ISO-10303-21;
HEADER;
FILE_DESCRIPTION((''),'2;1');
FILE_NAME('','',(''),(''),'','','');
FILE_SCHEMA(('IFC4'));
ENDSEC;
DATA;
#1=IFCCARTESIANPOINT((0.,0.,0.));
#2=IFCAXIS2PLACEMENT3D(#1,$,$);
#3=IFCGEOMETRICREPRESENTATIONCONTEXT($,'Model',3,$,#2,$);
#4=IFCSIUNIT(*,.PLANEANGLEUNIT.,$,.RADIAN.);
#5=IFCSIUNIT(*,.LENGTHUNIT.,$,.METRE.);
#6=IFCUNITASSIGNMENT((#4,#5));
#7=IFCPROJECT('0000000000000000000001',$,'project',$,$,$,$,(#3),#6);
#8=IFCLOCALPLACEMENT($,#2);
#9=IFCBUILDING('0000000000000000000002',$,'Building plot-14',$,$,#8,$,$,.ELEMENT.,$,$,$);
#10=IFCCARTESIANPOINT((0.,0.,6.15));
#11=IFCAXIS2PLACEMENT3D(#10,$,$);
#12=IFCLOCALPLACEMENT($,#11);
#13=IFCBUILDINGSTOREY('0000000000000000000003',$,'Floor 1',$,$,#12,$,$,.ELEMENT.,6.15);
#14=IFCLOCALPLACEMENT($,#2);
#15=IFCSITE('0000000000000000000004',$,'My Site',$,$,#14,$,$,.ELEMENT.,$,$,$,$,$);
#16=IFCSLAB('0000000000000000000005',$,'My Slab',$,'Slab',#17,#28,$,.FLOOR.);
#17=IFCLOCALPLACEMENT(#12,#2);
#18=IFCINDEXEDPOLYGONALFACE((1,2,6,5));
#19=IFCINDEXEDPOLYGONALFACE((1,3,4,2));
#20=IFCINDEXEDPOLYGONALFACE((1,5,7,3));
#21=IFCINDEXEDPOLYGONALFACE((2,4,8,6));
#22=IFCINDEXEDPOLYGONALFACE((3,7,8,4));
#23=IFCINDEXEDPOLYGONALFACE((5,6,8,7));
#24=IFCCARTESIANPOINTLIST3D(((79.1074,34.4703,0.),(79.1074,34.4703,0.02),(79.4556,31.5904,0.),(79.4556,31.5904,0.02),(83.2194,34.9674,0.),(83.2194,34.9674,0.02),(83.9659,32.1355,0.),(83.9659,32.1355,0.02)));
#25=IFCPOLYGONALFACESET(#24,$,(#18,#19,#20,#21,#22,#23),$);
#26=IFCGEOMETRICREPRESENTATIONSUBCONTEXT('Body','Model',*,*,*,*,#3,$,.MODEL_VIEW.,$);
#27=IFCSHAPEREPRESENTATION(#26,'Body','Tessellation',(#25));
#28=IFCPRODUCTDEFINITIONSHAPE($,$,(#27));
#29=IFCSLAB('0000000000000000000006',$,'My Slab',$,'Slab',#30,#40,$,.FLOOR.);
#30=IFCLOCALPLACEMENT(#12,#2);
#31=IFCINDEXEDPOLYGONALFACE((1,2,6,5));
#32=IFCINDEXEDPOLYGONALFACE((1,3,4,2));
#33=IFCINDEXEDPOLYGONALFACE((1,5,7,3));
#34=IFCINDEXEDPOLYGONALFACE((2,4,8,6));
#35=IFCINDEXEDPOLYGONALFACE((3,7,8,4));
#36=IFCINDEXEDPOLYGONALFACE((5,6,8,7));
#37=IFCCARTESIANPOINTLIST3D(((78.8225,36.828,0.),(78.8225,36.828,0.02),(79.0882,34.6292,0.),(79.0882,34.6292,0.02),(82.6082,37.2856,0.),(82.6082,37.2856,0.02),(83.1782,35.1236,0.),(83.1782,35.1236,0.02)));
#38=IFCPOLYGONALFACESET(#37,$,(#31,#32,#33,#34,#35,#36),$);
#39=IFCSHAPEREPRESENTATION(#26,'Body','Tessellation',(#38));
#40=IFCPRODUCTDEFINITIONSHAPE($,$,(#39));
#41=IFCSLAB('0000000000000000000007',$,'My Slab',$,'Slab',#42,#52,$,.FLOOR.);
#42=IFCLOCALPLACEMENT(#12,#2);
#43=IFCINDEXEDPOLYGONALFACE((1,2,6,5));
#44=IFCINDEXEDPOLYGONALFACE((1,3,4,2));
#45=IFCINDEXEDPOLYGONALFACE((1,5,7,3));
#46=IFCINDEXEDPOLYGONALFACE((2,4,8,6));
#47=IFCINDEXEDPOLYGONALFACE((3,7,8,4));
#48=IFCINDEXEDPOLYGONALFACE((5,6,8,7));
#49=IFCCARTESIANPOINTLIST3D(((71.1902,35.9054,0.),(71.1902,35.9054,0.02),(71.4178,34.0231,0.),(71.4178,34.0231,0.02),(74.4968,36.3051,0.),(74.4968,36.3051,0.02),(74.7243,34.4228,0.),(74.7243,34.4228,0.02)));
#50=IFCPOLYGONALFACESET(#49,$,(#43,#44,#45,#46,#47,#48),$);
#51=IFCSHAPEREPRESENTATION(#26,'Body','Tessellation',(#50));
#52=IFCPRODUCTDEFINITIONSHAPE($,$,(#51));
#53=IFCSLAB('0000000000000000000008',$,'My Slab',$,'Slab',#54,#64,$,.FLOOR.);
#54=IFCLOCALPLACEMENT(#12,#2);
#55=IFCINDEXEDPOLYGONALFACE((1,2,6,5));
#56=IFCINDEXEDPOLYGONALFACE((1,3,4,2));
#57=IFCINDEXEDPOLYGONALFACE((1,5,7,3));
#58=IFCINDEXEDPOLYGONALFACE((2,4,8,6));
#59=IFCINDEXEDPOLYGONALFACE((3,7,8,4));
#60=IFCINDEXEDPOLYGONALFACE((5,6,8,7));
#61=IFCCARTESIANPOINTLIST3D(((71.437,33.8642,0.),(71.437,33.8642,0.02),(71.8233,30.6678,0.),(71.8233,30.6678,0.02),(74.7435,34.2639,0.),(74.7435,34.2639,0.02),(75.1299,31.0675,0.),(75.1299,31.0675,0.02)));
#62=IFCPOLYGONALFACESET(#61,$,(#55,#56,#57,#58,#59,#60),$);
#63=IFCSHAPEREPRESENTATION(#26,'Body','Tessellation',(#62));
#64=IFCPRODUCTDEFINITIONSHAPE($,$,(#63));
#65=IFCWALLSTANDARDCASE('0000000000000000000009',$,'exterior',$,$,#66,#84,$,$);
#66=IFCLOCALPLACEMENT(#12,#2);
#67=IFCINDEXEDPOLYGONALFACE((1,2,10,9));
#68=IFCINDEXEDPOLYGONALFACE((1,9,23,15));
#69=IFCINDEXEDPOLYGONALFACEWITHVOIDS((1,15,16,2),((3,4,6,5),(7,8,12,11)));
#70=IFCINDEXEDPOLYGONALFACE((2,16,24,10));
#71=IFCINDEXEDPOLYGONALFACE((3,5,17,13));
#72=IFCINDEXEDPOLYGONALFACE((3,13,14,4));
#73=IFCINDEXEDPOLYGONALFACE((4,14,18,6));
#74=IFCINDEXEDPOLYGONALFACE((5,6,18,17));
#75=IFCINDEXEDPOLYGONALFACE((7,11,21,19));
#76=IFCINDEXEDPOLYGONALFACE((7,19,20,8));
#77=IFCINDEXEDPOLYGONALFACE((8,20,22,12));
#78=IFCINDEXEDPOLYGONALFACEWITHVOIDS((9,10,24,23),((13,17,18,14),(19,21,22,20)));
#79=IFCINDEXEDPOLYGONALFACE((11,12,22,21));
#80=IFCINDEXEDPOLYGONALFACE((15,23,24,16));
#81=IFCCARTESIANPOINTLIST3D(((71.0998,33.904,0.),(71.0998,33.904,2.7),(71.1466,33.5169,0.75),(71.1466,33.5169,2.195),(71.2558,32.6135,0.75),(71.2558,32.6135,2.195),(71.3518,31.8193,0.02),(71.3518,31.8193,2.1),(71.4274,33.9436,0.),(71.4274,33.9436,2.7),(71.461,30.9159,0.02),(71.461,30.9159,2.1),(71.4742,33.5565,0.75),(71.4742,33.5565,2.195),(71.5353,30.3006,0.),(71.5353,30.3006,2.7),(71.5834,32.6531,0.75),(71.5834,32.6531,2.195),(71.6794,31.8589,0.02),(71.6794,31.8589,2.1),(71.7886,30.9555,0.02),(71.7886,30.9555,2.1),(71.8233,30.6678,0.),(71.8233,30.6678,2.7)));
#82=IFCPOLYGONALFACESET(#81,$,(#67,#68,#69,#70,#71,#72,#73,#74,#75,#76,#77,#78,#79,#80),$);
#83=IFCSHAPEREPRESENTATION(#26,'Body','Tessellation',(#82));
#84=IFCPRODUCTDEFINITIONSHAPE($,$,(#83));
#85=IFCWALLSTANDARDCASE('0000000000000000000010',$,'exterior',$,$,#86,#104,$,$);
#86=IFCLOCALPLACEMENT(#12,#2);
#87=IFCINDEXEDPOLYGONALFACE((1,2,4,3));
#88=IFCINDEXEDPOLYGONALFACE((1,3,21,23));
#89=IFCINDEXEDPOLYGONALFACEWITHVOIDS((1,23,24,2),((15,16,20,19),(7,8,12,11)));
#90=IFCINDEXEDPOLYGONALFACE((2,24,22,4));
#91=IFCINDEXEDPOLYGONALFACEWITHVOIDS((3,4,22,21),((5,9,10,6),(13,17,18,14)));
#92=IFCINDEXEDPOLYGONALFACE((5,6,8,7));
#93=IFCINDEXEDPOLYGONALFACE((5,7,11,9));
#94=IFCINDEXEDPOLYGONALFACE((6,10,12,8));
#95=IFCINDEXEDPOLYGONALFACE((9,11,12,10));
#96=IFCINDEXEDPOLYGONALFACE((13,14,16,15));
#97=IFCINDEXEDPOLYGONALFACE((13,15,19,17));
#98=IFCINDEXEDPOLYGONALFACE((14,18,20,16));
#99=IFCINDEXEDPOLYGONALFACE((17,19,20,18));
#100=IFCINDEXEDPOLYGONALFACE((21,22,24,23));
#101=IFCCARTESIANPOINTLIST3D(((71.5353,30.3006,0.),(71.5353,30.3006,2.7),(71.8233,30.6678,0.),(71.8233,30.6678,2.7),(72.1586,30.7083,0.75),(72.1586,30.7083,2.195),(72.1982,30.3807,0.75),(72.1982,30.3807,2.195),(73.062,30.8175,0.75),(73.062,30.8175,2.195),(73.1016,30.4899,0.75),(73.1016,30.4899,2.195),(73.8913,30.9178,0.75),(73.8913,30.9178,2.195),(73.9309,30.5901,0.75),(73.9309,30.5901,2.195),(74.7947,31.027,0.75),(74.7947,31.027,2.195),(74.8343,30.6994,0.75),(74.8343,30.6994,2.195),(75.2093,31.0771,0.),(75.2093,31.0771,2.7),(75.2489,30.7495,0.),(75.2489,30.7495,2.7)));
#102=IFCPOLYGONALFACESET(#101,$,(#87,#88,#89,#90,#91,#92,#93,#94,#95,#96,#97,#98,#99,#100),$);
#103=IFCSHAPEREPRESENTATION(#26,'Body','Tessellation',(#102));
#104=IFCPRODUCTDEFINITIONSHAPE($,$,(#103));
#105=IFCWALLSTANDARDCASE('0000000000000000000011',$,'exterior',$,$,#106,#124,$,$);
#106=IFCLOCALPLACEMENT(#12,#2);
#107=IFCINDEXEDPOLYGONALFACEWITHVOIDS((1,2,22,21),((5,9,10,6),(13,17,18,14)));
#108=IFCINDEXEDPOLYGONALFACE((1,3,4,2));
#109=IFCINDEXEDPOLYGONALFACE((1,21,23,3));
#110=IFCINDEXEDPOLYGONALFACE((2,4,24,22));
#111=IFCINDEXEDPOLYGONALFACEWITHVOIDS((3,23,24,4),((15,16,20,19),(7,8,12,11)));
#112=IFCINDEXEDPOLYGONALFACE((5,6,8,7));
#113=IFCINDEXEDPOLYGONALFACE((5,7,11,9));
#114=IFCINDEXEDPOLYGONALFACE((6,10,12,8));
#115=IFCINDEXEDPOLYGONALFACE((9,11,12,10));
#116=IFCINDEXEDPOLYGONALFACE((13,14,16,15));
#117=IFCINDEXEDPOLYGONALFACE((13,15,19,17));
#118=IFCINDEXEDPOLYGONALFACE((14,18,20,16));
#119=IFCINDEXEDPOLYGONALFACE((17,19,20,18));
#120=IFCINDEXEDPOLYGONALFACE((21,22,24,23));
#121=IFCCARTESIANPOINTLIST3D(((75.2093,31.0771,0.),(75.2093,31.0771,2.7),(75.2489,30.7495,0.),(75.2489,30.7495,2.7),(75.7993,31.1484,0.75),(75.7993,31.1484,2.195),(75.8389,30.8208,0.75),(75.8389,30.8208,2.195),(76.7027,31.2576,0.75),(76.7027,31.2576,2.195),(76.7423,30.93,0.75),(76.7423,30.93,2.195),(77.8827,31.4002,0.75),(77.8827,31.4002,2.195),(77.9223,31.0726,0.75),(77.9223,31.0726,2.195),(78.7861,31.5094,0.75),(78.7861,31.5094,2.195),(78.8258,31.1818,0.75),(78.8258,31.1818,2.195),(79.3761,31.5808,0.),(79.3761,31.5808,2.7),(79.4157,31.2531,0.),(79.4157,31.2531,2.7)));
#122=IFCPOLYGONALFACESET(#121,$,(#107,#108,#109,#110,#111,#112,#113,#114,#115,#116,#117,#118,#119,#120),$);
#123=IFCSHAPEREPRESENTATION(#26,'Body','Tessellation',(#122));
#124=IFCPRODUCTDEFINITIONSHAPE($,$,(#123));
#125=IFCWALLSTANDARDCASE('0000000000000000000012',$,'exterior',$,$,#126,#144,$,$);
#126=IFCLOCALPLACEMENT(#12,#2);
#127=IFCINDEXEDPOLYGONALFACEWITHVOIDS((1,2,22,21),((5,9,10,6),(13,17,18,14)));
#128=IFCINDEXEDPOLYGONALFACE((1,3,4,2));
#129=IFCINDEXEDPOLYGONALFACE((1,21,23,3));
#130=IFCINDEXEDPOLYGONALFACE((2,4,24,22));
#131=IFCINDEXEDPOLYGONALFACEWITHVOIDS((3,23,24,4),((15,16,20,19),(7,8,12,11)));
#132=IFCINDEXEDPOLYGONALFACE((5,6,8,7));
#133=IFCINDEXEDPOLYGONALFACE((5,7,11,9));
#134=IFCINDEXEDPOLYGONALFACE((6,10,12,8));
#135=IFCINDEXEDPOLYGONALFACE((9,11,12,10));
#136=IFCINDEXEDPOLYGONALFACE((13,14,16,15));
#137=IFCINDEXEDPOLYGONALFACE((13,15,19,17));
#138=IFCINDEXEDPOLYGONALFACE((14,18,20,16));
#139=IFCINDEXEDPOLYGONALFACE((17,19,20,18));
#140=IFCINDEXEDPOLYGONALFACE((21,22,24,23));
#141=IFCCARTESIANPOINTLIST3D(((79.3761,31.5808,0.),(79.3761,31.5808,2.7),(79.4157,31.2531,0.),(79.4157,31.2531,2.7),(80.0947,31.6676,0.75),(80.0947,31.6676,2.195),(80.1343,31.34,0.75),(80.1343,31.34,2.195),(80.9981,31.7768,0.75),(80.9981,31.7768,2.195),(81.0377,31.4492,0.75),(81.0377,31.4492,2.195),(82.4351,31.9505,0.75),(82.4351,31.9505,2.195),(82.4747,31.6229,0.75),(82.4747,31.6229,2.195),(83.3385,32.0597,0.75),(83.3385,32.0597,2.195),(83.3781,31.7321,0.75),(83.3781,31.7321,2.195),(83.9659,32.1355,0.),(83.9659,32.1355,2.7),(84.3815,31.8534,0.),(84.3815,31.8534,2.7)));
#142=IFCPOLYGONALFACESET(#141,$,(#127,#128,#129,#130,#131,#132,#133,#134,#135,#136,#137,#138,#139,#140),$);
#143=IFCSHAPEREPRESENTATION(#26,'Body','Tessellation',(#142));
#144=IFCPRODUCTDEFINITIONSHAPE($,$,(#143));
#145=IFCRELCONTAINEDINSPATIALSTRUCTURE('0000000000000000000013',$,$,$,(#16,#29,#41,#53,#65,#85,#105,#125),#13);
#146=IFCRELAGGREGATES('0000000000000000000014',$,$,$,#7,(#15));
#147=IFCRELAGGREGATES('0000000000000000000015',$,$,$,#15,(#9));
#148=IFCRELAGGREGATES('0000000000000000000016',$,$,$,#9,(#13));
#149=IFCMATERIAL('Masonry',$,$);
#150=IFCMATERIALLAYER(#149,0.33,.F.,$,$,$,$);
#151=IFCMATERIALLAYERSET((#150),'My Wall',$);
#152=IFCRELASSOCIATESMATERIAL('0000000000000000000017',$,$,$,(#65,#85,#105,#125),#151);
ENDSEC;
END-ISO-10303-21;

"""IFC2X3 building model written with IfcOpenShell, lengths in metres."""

from ifc_helpers import new_model, si_unit, frame, origin, place, context, subcontext, project, spatial, polyline, outline, extrude, material, layer, layer_set, layer_usage, element, save


model = new_model("IFC2X3")

# Units and contexts
model_context = context("Model", 3, world=origin())
body_context = subcontext(model_context, "Body", "Model", "MODEL_VIEW")
ifc_project = project(units=[si_unit("PLANEANGLEUNIT", "RADIAN"), si_unit("LENGTHUNIT", "METRE")], contexts=[model_context])

# Site, building, storey
site_placement = place(None, origin())
site = spatial("IfcSite", under=ifc_project, at=site_placement, Name="My Site", CompositionType="ELEMENT")
building_placement = place(None, origin())
building = spatial("IfcBuilding", under=site, at=building_placement, Name="Building plot-14", CompositionType="ELEMENT")
storey_placement = place(None, frame((0.0, 0.0, 6.15)))
storey = spatial("IfcBuildingStorey", under=building, at=storey_placement, Name="Floor 1", CompositionType="ELEMENT", Elevation=6.15)

# Slabs
slab_1_placement = place(storey_placement, origin())
element("IfcSlab", 1, at=slab_1_placement, inside=storey, Name="My Slab", ObjectType="Slab", PredefinedType="FLOOR", context=body_context, shape_type="SweptSolid", body=[
    extrude(outline(polyline([(79.4556, 31.5904), (83.9659, 32.1355), (83.2194, 34.9674), (79.1074, 34.4703), (79.4556, 31.5904)])), origin(), (0.0, 0.0, 1.0), 0.02),
])
slab_2_placement = place(storey_placement, origin())
element("IfcSlab", 2, at=slab_2_placement, inside=storey, Name="My Slab", ObjectType="Slab", PredefinedType="FLOOR", context=body_context, shape_type="SweptSolid", body=[
    extrude(outline(polyline([(83.1782, 35.1236), (82.6082, 37.2856), (78.8225, 36.828), (79.0882, 34.6292), (83.1782, 35.1236)])), origin(), (0.0, 0.0, 1.0), 0.02),
])
slab_3_placement = place(storey_placement, origin())
element("IfcSlab", 3, at=slab_3_placement, inside=storey, Name="My Slab", ObjectType="Slab", PredefinedType="FLOOR", context=body_context, shape_type="SweptSolid", body=[
    extrude(outline(polyline([(74.7243, 34.4228), (74.4968, 36.3051), (71.1902, 35.9054), (71.4178, 34.0231), (74.7243, 34.4228)])), origin(), (0.0, 0.0, 1.0), 0.02),
])
slab_4_placement = place(storey_placement, origin())
element("IfcSlab", 4, at=slab_4_placement, inside=storey, Name="My Slab", ObjectType="Slab", PredefinedType="FLOOR", context=body_context, shape_type="SweptSolid", body=[
    extrude(outline(polyline([(75.1299, 31.0675), (74.7435, 34.2639), (71.437, 33.8642), (71.8233, 30.6678), (75.1299, 31.0675)])), origin(), (0.0, 0.0, 1.0), 0.02),
])

# Walls, openings
ifc_material = material(Name="Masonry")
ifc_layer = layer(ifc_material, 0.33, ventilated=False)
ifc_layer_set = layer_set([ifc_layer], Name="My Wall")
ifc_layer_usage = layer_usage(ifc_layer_set, "AXIS2", "NEGATIVE", 0.08)
wall_1_placement = place(storey_placement, origin())
wall_1 = element("IfcWallStandardCase", 5, at=wall_1_placement, inside=storey, material=ifc_layer_usage, Name="exterior", context=body_context, shape_type="SweptSolid", body=[
    extrude(outline(polyline([(71.4274, 33.9436), (71.0998, 33.904), (71.5353, 30.3006), (71.8233, 30.6678), (71.4274, 33.9436)])), origin(), (0.0, 0.0, 1.0), 2.7),
])
opening_1_placement = place(storey_placement, frame((0.0, 0.0, 0.75)))
element("IfcOpeningElement", 6, at=opening_1_placement, cuts=wall_1, ObjectType="Opening", context=body_context, shape_type="SweptSolid", body=[
    extrude(outline(polyline([(71.1466, 33.5169), (71.2558, 32.6135), (71.5834, 32.6531), (71.4742, 33.5565), (71.1466, 33.5169)])), origin(), (0.0, 0.0, 1.0), 1.445),
])
opening_2_placement = place(storey_placement, frame((0.0, 0.0, 0.02)))
element("IfcOpeningElement", 7, at=opening_2_placement, cuts=wall_1, ObjectType="Opening", context=body_context, shape_type="SweptSolid", body=[
    extrude(outline(polyline([(71.3518, 31.8193), (71.461, 30.9159), (71.7886, 30.9555), (71.6794, 31.8589), (71.3518, 31.8193)])), origin(), (0.0, 0.0, 1.0), 2.08),
])
wall_2_placement = place(storey_placement, origin())
wall_2 = element("IfcWallStandardCase", 8, at=wall_2_placement, inside=storey, material=ifc_layer_usage, Name="exterior", context=body_context, shape_type="SweptSolid", body=[
    extrude(outline(polyline([(71.8233, 30.6678), (71.5353, 30.3006), (75.2489, 30.7495), (75.2093, 31.0771), (71.8233, 30.6678)])), origin(), (0.0, 0.0, 1.0), 2.7),
])
opening_3_placement = place(storey_placement, frame((0.0, 0.0, 0.75)))
element("IfcOpeningElement", 9, at=opening_3_placement, cuts=wall_2, ObjectType="Opening", context=body_context, shape_type="SweptSolid", body=[
    extrude(outline(polyline([(72.1982, 30.3807), (73.1016, 30.4899), (73.062, 30.8175), (72.1586, 30.7083), (72.1982, 30.3807)])), origin(), (0.0, 0.0, 1.0), 1.445),
])
opening_4_placement = place(storey_placement, frame((0.0, 0.0, 0.75)))
element("IfcOpeningElement", 10, at=opening_4_placement, cuts=wall_2, ObjectType="Opening", context=body_context, shape_type="SweptSolid", body=[
    extrude(outline(polyline([(73.9309, 30.5901), (74.8343, 30.6994), (74.7947, 31.027), (73.8913, 30.9178), (73.9309, 30.5901)])), origin(), (0.0, 0.0, 1.0), 1.445),
])
wall_3_placement = place(storey_placement, origin())
wall_3 = element("IfcWallStandardCase", 11, at=wall_3_placement, inside=storey, material=ifc_layer_usage, Name="exterior", context=body_context, shape_type="SweptSolid", body=[
    extrude(outline(polyline([(75.2093, 31.0771), (75.2489, 30.7495), (79.4157, 31.2531), (79.3761, 31.5808), (75.2093, 31.0771)])), origin(), (0.0, 0.0, 1.0), 2.7),
])
opening_5_placement = place(storey_placement, frame((0.0, 0.0, 0.75)))
element("IfcOpeningElement", 12, at=opening_5_placement, cuts=wall_3, ObjectType="Opening", context=body_context, shape_type="SweptSolid", body=[
    extrude(outline(polyline([(75.8389, 30.8208), (76.7423, 30.93), (76.7027, 31.2576), (75.7993, 31.1484), (75.8389, 30.8208)])), origin(), (0.0, 0.0, 1.0), 1.445),
])
opening_6_placement = place(storey_placement, frame((0.0, 0.0, 0.75)))
element("IfcOpeningElement", 13, at=opening_6_placement, cuts=wall_3, ObjectType="Opening", context=body_context, shape_type="SweptSolid", body=[
    extrude(outline(polyline([(77.9223, 31.0726), (78.8258, 31.1818), (78.7861, 31.5094), (77.8827, 31.4002), (77.9223, 31.0726)])), origin(), (0.0, 0.0, 1.0), 1.445),
])
wall_4_placement = place(storey_placement, origin())
wall_4 = element("IfcWallStandardCase", 14, at=wall_4_placement, inside=storey, material=ifc_layer_usage, Name="exterior", context=body_context, shape_type="SweptSolid", body=[
    extrude(outline(polyline([(79.3761, 31.5808), (79.4157, 31.2531), (84.3815, 31.8534), (83.9659, 32.1355), (79.3761, 31.5808)])), origin(), (0.0, 0.0, 1.0), 2.7),
])
opening_7_placement = place(storey_placement, frame((0.0, 0.0, 0.75)))
element("IfcOpeningElement", 15, at=opening_7_placement, cuts=wall_4, ObjectType="Opening", context=body_context, shape_type="SweptSolid", body=[
    extrude(outline(polyline([(80.1343, 31.34), (81.0377, 31.4492), (80.9981, 31.7768), (80.0947, 31.6676), (80.1343, 31.34)])), origin(), (0.0, 0.0, 1.0), 1.445),
])
opening_8_placement = place(storey_placement, frame((0.0, 0.0, 0.75)))
element("IfcOpeningElement", 16, at=opening_8_placement, cuts=wall_4, ObjectType="Opening", context=body_context, shape_type="SweptSolid", body=[
    extrude(outline(polyline([(82.4747, 31.6229), (83.3781, 31.7321), (83.3385, 32.0597), (82.4351, 31.9505), (82.4747, 31.6229)])), origin(), (0.0, 0.0, 1.0), 1.445),
])

save(model, "model.ifc")
